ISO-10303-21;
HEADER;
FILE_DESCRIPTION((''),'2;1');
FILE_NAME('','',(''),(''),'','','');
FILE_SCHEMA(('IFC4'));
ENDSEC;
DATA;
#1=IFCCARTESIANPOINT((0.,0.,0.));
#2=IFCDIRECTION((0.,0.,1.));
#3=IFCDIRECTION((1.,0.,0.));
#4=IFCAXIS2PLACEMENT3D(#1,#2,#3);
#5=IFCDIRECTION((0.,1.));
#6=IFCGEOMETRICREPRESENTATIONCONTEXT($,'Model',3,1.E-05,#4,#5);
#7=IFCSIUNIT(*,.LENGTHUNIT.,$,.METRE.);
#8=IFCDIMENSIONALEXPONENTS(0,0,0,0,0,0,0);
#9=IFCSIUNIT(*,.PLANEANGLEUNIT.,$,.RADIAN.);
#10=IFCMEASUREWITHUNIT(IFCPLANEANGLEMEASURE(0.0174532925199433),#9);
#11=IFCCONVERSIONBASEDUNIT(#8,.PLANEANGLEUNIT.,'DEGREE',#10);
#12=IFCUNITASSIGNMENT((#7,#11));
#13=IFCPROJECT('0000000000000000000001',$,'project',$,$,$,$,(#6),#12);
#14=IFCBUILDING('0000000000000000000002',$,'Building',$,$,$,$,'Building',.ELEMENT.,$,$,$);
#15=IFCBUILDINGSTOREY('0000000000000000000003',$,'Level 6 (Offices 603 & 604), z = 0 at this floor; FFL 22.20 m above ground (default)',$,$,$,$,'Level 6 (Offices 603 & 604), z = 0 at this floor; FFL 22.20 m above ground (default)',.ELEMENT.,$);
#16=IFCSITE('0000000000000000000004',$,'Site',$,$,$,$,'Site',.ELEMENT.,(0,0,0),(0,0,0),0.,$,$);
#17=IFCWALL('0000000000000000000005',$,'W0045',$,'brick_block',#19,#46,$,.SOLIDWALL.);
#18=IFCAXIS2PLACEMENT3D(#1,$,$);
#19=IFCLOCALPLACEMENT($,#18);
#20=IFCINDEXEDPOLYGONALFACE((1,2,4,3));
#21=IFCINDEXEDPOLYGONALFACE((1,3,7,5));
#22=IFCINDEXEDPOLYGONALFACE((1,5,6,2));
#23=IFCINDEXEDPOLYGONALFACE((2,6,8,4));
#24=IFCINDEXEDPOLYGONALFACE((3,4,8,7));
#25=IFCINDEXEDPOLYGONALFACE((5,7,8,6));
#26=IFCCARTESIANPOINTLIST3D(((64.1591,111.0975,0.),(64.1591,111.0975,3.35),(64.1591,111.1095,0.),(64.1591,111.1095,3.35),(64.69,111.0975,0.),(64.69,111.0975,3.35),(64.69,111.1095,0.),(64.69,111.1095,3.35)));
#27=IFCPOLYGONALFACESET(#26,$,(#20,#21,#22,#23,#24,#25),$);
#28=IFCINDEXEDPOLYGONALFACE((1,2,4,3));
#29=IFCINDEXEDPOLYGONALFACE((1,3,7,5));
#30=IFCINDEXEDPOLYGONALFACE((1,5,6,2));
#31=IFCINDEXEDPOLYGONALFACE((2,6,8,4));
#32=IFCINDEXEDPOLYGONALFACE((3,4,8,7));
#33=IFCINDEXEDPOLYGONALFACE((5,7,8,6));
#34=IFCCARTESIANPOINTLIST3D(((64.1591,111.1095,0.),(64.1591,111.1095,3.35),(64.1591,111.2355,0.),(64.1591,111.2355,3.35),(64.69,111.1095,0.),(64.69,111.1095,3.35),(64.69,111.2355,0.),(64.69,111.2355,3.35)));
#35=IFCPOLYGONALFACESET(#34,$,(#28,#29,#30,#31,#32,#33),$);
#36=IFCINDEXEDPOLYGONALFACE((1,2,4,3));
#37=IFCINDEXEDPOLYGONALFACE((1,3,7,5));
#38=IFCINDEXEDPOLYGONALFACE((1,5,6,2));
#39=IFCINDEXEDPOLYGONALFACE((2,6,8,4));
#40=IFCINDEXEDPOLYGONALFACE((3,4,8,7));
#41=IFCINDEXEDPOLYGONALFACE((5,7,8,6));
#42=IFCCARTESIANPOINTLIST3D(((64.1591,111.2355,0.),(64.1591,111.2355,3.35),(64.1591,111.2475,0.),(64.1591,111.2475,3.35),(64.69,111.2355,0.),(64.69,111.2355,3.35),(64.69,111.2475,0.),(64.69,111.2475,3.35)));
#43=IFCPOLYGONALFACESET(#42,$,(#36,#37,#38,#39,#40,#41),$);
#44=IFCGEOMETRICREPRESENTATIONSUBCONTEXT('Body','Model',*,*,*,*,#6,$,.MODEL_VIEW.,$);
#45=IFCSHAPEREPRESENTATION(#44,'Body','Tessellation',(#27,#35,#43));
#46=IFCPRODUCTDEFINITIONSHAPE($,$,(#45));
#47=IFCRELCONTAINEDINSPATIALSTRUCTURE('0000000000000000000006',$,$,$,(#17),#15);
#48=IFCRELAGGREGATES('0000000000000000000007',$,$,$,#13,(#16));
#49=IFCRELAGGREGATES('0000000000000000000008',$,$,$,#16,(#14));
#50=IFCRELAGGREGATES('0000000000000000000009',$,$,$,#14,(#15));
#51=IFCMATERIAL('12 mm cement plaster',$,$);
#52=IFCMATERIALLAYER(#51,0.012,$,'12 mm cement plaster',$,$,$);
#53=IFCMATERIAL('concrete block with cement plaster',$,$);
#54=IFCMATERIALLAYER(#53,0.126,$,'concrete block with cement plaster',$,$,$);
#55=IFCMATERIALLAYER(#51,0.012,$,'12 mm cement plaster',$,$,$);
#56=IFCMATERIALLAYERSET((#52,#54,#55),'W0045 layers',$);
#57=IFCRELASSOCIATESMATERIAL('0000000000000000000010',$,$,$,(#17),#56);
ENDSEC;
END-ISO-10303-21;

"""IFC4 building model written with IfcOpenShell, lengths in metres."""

from ifc_helpers import new_model, entity, si_unit, converted_unit, direction, frame, frame_2d, origin_with_axes, place, context, subcontext, project, spatial, rectangle, extrude, material, layer, layer_set, layer_usage, element, save


model = new_model("IFC4")

# Units and contexts
model_context = context("Model", 3, precision=1e-05, world=origin_with_axes(), true_north=direction((0.0, 1.0)))
body_context = subcontext(model_context, "Body", "Model", "MODEL_VIEW")
ifc_project = project(units=[si_unit("LENGTHUNIT", "METRE"), converted_unit("PLANEANGLEUNIT", "DEGREE", entity("IfcPlaneAngleMeasure", 0.0174532925199433), si_unit("PLANEANGLEUNIT", "RADIAN"), dimensions=[0, 0, 0, 0, 0, 0, 0])], contexts=[model_context])

# Site, building, storey
site = spatial("IfcSite", under=ifc_project, Name="Site", LongName="Site", CompositionType="ELEMENT", RefLatitude=(0, 0, 0), RefLongitude=(0, 0, 0), RefElevation=0.0)
building = spatial("IfcBuilding", under=site, Name="Building", LongName="Building", CompositionType="ELEMENT")
storey = spatial("IfcBuildingStorey", under=building, Name="Level 6 (Offices 603 & 604), z = 0 at this floor; FFL 22.20 m above ground (default)", LongName="Level 6 (Offices 603 & 604), z = 0 at this floor; FFL 22.20 m above ground (default)", CompositionType="ELEMENT")

# Shared definitions
ifc_material_1 = material(Name="12 mm cement plaster")
ifc_material_2 = material(Name="concrete block with cement plaster")
placement = place(None, origin_with_axes())

# Wall
ifc_layer_1 = layer(ifc_material_1, 0.012, Name="12 mm cement plaster")
ifc_layer_2 = layer(ifc_material_2, 0.126, Name="concrete block with cement plaster")
ifc_layer_3 = layer(ifc_material_1, 0.012, Name="12 mm cement plaster")
ifc_layer_set_1 = layer_set([ifc_layer_1, ifc_layer_2, ifc_layer_3], Name="W0045 layers")
ifc_layer_usage_1 = layer_usage(ifc_layer_set_1, "AXIS2", "POSITIVE", -0.075)
element("IfcWall", 1, at=placement, inside=storey, material=ifc_layer_usage_1, Name="W0045", ObjectType="brick_block", PredefinedType="SOLIDWALL", context=body_context, shape_type="SweptSolid", body=[
    extrude(rectangle(XDim=0.5309, YDim=0.012, at=frame_2d((0.0, 0.0), x_axis=(1.0, 0.0))), frame((64.4245, 111.1035, 0.0), z_axis=(0.0, 0.0, 1.0), x_axis=(1.0, 0.0, 0.0)), (0.0, 0.0, 1.0), 3.35),
    extrude(rectangle(XDim=0.5309, YDim=0.126, at=frame_2d((0.0, 0.069), x_axis=(1.0, 0.0))), frame((64.4245, 111.1035, 0.0), z_axis=(0.0, 0.0, 1.0), x_axis=(1.0, 0.0, 0.0)), (0.0, 0.0, 1.0), 3.35),
    extrude(rectangle(XDim=0.5309, YDim=0.012, at=frame_2d((0.0, 0.138), x_axis=(1.0, 0.0))), frame((64.4245, 111.1035, 0.0), z_axis=(0.0, 0.0, 1.0), x_axis=(1.0, 0.0, 0.0)), (0.0, 0.0, 1.0), 3.35),
])

save(model, "model.ifc")
